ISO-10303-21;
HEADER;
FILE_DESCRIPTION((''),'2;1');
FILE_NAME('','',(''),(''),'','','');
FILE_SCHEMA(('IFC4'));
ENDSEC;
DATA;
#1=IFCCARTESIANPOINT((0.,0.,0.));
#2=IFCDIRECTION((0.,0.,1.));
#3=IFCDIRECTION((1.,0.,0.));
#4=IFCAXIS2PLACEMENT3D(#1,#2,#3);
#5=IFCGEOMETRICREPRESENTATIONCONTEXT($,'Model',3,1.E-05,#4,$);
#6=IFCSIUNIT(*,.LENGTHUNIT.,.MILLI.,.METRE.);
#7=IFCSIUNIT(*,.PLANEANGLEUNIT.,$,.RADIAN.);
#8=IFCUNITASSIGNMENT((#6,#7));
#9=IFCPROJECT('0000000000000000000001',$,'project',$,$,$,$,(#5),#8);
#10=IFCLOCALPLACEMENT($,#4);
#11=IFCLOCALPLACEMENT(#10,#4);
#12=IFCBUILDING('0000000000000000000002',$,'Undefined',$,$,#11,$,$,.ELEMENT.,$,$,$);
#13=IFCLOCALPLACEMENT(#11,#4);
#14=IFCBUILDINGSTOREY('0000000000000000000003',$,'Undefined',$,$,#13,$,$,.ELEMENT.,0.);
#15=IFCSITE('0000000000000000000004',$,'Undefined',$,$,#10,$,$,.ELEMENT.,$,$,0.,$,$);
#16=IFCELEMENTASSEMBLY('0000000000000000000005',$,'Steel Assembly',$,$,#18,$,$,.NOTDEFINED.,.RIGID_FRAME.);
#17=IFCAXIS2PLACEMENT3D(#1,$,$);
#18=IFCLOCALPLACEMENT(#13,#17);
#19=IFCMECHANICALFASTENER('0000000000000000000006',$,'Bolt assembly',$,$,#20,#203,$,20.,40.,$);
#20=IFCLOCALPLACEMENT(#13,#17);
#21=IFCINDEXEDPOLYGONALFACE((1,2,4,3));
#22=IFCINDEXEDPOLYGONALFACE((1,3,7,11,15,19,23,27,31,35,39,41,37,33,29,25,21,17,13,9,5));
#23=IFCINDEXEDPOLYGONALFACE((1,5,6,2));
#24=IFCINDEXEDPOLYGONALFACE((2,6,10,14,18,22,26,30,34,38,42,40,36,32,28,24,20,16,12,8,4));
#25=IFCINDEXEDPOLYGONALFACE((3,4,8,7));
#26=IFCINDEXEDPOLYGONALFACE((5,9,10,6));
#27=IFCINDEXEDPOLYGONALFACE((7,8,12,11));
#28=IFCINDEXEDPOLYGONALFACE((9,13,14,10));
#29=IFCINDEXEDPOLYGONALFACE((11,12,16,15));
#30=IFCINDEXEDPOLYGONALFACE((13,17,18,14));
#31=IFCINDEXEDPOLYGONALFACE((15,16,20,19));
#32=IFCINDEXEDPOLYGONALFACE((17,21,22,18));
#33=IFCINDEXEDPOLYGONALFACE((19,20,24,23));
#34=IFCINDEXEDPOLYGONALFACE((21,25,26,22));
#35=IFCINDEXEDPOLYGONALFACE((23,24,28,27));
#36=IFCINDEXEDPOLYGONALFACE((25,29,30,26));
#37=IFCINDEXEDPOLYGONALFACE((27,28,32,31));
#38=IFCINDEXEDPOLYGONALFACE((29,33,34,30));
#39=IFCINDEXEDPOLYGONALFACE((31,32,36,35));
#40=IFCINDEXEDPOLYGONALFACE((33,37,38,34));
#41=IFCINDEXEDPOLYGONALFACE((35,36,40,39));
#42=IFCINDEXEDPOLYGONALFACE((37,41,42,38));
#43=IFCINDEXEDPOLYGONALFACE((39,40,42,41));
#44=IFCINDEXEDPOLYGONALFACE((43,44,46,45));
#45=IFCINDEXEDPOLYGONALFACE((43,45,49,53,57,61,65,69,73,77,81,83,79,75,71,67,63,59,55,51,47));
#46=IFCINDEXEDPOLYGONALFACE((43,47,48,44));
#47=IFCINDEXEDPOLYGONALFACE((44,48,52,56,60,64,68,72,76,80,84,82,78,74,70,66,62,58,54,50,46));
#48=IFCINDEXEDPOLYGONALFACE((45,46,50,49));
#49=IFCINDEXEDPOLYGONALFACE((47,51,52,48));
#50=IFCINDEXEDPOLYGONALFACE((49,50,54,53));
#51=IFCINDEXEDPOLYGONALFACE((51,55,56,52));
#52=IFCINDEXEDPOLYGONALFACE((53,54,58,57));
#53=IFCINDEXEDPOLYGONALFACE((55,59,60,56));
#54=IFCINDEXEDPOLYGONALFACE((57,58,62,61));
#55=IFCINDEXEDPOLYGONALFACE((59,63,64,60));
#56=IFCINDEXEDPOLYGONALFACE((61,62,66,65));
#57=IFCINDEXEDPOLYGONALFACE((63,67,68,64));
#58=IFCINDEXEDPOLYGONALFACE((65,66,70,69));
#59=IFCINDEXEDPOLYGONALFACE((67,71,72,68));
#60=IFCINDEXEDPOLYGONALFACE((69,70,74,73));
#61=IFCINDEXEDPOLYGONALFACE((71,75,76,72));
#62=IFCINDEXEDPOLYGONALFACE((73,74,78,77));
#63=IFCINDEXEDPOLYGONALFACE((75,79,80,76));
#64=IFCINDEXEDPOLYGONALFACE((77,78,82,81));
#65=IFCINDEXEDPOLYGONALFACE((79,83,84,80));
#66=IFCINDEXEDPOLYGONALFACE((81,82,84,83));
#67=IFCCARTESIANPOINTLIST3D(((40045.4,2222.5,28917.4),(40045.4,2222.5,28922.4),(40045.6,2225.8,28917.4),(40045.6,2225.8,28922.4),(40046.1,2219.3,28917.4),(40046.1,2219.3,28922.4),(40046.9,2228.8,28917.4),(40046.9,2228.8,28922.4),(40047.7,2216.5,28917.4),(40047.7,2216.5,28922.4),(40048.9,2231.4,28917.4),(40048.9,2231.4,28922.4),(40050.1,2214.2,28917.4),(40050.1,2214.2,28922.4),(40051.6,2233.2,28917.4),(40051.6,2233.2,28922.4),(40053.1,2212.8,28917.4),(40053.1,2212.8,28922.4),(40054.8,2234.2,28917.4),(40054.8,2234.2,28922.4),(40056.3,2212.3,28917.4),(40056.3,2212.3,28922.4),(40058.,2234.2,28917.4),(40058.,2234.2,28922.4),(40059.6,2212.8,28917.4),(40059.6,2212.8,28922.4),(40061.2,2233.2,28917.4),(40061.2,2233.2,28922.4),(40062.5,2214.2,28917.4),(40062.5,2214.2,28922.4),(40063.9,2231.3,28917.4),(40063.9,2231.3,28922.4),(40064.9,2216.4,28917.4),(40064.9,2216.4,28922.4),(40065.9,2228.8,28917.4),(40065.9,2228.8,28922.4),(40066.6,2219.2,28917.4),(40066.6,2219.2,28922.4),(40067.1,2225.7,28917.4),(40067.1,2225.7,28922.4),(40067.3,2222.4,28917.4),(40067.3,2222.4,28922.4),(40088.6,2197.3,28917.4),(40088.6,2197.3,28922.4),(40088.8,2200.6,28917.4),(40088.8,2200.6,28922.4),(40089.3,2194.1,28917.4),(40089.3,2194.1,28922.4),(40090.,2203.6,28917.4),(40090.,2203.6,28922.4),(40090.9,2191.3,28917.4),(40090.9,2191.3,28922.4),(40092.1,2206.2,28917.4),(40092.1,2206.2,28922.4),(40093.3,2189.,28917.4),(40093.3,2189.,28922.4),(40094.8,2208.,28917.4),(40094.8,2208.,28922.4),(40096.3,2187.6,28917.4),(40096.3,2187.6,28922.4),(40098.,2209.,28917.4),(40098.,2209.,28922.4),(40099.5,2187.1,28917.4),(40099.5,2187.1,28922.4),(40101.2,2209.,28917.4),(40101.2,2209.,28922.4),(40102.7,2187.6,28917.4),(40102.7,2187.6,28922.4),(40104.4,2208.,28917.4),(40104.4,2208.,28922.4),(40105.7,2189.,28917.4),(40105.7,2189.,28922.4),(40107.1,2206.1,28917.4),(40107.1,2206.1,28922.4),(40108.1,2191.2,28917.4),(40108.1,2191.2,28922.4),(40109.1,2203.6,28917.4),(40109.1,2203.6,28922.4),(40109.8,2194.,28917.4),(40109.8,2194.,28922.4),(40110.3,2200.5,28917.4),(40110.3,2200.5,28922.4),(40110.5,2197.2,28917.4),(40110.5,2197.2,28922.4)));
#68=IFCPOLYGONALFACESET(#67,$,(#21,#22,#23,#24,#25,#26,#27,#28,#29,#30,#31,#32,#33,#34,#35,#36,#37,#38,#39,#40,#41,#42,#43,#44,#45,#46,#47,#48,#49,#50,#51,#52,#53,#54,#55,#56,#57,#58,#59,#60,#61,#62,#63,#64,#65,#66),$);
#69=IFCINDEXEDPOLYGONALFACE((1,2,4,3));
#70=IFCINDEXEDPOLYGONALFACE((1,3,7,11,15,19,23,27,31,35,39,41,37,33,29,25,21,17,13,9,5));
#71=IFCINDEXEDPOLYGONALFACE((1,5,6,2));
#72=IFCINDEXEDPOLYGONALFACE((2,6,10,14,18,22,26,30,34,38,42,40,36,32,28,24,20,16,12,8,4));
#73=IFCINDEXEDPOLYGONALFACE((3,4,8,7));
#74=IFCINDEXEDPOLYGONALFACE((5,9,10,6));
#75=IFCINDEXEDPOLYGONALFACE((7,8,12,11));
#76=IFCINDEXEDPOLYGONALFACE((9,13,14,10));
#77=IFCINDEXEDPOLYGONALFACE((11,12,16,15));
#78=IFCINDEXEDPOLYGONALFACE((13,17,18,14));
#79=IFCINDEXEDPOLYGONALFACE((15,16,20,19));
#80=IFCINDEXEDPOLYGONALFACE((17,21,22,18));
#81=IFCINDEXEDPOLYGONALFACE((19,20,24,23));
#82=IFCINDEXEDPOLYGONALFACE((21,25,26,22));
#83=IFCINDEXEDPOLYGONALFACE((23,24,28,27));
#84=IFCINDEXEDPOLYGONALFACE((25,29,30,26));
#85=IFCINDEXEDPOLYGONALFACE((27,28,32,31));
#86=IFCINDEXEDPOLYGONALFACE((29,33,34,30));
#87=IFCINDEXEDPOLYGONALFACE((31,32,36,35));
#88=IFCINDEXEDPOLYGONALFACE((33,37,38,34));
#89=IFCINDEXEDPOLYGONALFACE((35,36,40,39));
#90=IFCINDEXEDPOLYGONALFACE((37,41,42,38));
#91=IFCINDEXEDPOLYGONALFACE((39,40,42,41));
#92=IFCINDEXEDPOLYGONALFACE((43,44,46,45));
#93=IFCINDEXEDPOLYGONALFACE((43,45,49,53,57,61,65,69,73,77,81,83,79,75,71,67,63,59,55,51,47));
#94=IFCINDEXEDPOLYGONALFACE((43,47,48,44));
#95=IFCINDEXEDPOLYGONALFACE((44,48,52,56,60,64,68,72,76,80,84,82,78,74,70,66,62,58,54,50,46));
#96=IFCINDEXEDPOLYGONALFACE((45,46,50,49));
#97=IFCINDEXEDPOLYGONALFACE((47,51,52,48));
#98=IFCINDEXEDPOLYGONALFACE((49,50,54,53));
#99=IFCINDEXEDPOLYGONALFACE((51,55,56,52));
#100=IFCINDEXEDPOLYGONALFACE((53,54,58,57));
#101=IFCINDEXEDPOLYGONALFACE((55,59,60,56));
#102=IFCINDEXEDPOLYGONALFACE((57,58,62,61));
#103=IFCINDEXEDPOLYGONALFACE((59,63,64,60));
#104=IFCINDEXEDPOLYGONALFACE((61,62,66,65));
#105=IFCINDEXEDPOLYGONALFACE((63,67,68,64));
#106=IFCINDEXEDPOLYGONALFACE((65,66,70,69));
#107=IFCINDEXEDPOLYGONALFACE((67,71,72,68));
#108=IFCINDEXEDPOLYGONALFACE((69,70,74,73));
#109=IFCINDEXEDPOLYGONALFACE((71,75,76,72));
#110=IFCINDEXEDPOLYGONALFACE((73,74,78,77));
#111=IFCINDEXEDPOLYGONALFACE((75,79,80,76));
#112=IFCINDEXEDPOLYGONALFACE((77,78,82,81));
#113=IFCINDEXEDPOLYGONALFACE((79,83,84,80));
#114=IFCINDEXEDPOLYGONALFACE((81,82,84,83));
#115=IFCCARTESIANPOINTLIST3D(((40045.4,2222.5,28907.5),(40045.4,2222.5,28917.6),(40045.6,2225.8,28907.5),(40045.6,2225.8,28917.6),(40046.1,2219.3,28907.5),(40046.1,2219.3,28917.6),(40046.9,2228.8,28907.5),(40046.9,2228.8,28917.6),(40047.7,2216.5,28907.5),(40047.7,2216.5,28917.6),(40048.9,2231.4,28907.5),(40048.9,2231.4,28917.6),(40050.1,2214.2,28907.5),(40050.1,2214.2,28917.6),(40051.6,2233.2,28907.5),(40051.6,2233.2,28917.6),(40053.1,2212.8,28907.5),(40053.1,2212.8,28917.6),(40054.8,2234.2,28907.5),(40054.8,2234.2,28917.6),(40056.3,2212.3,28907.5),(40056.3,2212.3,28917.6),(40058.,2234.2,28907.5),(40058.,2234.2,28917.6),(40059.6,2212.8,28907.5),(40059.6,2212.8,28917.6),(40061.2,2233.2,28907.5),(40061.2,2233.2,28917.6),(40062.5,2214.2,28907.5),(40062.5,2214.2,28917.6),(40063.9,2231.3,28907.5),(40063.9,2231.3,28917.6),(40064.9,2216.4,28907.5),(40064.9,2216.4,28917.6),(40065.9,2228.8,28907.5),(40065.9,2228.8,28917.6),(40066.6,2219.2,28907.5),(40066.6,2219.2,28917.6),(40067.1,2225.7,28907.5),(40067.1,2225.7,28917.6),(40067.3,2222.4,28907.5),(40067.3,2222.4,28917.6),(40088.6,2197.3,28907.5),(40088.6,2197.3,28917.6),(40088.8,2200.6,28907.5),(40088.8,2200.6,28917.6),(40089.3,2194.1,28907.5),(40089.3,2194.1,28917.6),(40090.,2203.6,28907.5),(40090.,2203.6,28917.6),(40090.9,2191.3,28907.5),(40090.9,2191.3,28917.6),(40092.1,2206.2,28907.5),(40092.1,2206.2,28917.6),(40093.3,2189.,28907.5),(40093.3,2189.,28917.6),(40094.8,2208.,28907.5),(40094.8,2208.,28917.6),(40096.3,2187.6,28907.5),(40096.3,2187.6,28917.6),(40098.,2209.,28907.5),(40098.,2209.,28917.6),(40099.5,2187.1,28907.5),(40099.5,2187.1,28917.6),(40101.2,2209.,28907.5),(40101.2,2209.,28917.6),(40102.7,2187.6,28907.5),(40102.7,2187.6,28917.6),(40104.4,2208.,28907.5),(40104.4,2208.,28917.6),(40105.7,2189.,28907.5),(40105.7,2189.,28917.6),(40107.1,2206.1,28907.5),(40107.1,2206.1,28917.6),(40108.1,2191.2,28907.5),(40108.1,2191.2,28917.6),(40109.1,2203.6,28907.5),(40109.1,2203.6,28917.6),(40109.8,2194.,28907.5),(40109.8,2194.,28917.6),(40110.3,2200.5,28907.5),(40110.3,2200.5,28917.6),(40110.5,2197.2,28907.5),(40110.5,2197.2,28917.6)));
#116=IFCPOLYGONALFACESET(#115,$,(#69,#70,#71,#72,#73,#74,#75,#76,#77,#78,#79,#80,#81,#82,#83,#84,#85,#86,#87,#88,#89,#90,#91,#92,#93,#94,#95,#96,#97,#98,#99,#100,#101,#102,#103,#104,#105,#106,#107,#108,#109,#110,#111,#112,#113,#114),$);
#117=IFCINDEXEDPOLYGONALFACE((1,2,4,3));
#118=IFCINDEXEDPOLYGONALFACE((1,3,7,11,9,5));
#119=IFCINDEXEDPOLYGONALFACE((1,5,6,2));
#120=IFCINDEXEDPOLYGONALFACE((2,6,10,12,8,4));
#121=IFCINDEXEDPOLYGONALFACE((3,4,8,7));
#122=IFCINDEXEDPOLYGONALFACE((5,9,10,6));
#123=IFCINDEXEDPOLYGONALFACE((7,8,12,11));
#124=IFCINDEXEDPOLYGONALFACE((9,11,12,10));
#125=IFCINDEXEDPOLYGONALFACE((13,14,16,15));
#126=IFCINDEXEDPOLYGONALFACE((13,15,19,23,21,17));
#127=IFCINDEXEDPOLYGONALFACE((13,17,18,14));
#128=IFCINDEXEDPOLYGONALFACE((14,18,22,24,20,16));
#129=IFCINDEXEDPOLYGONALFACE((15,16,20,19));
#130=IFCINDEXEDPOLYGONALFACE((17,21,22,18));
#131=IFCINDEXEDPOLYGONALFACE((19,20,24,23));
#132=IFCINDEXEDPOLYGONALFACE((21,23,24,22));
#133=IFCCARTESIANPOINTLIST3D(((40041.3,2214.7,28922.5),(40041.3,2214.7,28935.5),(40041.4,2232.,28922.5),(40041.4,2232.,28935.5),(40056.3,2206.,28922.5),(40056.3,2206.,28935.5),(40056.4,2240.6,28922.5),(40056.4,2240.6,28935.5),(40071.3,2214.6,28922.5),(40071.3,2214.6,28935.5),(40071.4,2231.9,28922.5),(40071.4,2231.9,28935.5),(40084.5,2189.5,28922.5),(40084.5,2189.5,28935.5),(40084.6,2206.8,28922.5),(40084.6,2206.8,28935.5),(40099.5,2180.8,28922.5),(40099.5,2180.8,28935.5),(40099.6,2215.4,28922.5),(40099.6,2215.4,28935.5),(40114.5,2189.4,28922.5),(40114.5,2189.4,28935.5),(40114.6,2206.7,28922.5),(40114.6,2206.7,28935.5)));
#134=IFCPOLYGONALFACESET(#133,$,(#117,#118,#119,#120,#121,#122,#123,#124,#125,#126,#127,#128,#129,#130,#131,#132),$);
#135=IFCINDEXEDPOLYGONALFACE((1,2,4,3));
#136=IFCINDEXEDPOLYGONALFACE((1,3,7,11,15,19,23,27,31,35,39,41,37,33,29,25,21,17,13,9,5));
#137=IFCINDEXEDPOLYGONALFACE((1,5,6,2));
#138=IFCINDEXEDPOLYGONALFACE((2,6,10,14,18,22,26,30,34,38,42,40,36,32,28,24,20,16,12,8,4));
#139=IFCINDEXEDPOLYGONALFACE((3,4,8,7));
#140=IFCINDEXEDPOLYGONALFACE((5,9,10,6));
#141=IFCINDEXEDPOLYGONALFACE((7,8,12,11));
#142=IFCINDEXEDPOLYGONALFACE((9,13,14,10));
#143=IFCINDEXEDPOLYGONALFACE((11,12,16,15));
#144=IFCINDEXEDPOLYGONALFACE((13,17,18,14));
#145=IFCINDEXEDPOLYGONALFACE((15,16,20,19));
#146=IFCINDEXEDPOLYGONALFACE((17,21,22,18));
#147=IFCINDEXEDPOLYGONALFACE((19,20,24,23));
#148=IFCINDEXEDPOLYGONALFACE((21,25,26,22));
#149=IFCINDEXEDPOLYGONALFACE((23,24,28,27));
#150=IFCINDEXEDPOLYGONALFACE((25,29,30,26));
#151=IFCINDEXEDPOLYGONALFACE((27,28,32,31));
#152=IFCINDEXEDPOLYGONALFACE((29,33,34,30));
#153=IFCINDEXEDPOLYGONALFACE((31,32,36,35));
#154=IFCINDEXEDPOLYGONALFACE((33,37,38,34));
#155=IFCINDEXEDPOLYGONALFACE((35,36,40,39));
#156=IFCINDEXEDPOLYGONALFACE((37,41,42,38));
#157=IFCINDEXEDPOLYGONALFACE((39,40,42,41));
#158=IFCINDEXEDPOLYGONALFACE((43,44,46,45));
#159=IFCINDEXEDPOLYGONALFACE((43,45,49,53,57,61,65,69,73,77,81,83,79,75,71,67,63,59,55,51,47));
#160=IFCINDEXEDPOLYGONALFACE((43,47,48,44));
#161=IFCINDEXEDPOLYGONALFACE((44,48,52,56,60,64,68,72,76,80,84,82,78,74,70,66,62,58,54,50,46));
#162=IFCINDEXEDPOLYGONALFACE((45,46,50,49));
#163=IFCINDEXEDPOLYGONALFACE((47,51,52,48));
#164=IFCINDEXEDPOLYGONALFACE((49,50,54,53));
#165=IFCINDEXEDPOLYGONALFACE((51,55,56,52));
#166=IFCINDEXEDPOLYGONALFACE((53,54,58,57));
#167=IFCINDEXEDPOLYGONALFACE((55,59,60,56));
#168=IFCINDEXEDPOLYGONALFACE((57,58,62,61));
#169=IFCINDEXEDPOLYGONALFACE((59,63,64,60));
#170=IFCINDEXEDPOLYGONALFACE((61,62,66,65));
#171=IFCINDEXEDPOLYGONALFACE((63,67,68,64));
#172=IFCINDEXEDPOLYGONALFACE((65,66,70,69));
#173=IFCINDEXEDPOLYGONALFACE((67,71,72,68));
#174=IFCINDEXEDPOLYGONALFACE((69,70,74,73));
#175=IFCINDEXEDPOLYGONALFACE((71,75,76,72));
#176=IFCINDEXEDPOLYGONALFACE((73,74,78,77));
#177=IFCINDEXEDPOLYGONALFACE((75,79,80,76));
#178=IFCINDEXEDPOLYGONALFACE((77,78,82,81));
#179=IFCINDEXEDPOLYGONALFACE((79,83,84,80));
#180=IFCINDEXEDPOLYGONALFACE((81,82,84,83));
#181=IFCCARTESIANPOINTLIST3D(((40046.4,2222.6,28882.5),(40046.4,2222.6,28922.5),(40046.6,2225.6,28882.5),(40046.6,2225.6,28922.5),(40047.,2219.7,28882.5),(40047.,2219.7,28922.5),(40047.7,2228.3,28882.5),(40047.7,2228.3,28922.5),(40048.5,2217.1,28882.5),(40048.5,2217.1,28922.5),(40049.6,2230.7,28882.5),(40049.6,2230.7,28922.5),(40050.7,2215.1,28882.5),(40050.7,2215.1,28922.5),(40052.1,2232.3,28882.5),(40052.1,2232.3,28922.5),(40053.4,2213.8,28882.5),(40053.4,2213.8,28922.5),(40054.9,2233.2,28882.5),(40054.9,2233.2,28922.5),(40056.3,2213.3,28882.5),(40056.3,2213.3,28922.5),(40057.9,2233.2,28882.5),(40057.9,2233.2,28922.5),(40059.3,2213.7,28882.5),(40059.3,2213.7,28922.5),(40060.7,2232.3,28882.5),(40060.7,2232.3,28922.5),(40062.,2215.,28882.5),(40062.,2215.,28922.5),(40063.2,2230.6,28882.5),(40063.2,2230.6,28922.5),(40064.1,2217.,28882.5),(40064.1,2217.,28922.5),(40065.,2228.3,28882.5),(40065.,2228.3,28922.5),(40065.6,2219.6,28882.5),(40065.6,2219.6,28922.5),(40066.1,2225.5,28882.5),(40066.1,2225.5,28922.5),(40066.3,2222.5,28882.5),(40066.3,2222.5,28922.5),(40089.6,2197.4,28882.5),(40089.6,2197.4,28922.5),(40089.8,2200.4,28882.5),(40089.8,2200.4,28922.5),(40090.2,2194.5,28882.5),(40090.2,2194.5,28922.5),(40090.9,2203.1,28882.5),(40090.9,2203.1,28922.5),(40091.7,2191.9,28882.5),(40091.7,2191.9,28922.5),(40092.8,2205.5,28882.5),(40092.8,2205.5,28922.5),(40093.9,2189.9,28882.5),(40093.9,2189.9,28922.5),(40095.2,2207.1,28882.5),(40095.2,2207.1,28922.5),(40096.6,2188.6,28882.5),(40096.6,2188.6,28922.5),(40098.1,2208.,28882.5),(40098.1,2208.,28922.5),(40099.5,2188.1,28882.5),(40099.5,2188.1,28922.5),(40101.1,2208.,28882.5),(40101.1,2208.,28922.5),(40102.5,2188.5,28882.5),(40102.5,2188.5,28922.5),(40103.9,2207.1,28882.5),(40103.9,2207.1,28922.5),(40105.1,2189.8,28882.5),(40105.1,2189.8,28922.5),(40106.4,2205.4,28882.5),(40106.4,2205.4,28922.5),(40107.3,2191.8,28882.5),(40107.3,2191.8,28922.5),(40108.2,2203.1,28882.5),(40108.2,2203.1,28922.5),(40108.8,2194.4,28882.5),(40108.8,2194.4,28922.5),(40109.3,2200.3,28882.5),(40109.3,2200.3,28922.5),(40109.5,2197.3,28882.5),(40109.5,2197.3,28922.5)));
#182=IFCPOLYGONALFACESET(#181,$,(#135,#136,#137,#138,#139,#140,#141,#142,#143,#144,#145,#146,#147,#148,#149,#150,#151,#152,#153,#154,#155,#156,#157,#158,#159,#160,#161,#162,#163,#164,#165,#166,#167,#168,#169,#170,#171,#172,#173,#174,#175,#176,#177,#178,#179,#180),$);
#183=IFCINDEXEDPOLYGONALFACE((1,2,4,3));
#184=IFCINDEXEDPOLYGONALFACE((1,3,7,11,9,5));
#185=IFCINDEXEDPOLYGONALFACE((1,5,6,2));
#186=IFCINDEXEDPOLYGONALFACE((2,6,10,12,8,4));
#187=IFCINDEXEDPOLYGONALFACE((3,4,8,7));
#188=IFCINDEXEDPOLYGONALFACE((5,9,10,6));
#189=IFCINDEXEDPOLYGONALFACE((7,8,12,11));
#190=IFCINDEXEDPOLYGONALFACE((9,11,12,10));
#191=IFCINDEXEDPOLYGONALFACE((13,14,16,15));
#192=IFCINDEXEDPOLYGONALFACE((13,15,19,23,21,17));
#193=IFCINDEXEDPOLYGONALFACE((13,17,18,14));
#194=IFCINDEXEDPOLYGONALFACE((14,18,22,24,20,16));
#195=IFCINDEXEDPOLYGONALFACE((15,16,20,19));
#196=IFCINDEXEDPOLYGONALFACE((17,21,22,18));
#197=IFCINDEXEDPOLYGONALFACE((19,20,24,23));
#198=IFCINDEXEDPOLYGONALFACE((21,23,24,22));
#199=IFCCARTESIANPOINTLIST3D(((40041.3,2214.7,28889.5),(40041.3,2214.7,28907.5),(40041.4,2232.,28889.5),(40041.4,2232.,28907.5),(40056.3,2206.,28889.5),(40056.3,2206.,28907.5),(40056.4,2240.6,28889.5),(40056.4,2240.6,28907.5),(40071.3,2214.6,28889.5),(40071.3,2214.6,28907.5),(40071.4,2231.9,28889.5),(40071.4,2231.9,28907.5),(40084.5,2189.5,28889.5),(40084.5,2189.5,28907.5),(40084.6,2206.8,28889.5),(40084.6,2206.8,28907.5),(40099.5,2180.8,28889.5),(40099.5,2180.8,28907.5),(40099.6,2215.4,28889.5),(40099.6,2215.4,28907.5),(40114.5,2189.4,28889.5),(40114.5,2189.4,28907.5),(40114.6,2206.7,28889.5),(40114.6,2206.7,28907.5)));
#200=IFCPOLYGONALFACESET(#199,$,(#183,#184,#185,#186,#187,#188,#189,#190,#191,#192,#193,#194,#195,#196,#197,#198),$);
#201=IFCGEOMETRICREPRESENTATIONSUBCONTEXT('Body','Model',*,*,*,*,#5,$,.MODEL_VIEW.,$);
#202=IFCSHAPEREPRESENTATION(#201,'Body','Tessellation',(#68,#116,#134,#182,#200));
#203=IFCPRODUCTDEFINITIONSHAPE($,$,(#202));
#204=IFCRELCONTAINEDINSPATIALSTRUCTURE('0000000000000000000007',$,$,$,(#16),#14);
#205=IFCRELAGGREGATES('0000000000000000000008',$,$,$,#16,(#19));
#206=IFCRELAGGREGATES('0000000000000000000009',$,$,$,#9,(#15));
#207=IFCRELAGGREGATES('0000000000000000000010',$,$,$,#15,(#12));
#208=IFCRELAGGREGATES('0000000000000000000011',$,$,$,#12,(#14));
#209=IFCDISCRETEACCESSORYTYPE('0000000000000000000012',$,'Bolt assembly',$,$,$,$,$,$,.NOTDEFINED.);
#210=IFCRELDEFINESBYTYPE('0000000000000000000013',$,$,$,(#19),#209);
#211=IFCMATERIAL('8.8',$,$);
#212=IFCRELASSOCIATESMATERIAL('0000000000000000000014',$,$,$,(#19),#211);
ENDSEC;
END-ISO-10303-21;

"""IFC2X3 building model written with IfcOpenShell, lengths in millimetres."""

from ifc_helpers import new_model, si_unit, frame, origin_with_axes, origin_2d_with_axis, place, context, subcontext, project, spatial, polyline, circle, outline, extrude, source, transform, mapped, material, type_object, element, aggregate, save


model = new_model("IFC2X3")

# Units and contexts
model_context = context("Model", 3, precision=1e-05, world=origin_with_axes())
body_context = subcontext(model_context, "Body", "Model", "MODEL_VIEW")
ifc_project = project(units=[si_unit("LENGTHUNIT", "METRE", prefix="MILLI"), si_unit("PLANEANGLEUNIT", "RADIAN")], contexts=[model_context])

# Site, building, storey
site_placement = place(None, origin_with_axes())
site = spatial("IfcSite", under=ifc_project, at=site_placement, Name="Undefined", CompositionType="ELEMENT", RefElevation=0.0)
building_placement = place(site_placement, origin_with_axes())
building = spatial("IfcBuilding", under=site, at=building_placement, Name="Undefined", CompositionType="ELEMENT")
storey_placement = place(building_placement, origin_with_axes())
storey = spatial("IfcBuildingStorey", under=building, at=storey_placement, Name="Undefined", CompositionType="ELEMENT", Elevation=0.0)

# Shared definitions
discrete_accessory_type_1 = type_object("IfcDiscreteAccessoryType", Name="Bolt assembly")

# Shared definitions
ifc_material_1 = material(Name="8.8")

# Element assembly, mechanical fastener
shared_shape_1 = source(origin_with_axes(), body_context, "Body", "SweptSolid", [
    extrude(circle(Radius=11.0, at=origin_2d_with_axis()), frame((0.0, 0.1, 0.0), z_axis=(0.0, 1.0, 0.0), x_axis=(1.0, 0.0, 0.0)), (0.0, 0.0, 1.0), 5.0),
    extrude(circle(Radius=11.0, at=origin_2d_with_axis()), frame((0.0, 4.9, 0.0), z_axis=(0.0, 1.0, 0.0), x_axis=(1.0, 0.0, 0.0)), (0.0, 0.0, 1.0), 10.1),
    extrude(outline(polyline([(17.3, 0.0), (8.7, 15.0), (-8.7, 15.0), (-17.3, 0.0), (-8.7, -15.0), (8.7, -15.0), (17.3, 0.0)])), frame((0.0, -13.0, 0.0), z_axis=(0.0, 1.0, 0.0), x_axis=(1.0, 0.0, 0.0)), (0.0, 0.0, 1.0), 13.0),
    extrude(circle(Radius=10.0, at=origin_2d_with_axis()), frame((0.0, 0.0, 0.0), z_axis=(0.0, 1.0, 0.0), x_axis=(1.0, 0.0, 0.0)), (0.0, 0.0, 1.0), 40.0),
    extrude(outline(polyline([(17.3, 0.0), (8.7, 15.0), (-8.7, 15.0), (-17.3, 0.0), (-8.7, -15.0), (8.7, -15.0), (17.3, 0.0)])), frame((0.0, 15.0, 0.0), z_axis=(0.0, 1.0, 0.0), x_axis=(1.0, 0.0, 0.0)), (0.0, 0.0, 1.0), 18.0),
])
assembly_1_placement = place(storey_placement, origin_with_axes())
assembly_1 = element("IfcElementAssembly", 1, at=assembly_1_placement, inside=storey, Name="Steel Assembly", AssemblyPlace="NOTDEFINED", PredefinedType="RIGID_FRAME")
mechanical_fastener_1_placement = place(assembly_1_placement, frame((40099.5, 2198.1, 28922.5), z_axis=(-0.503714, -0.86387, 0.0), x_axis=(-0.86387, 0.503714, 0.0)))
mechanical_fastener_1 = element("IfcMechanicalFastener", 2, at=mechanical_fastener_1_placement, type_object=discrete_accessory_type_1, material=ifc_material_1, Name="Bolt assembly", NominalDiameter=20.0, NominalLength=40.0, context=body_context, shape_type="MappedRepresentation", body=[
    mapped(shared_shape_1, transform((0.0, 0.0, 0.0))),
    mapped(shared_shape_1, transform((50.0, 0.0, 0.0))),
])

aggregate(assembly_1, [mechanical_fastener_1])

save(model, "model.ifc")
